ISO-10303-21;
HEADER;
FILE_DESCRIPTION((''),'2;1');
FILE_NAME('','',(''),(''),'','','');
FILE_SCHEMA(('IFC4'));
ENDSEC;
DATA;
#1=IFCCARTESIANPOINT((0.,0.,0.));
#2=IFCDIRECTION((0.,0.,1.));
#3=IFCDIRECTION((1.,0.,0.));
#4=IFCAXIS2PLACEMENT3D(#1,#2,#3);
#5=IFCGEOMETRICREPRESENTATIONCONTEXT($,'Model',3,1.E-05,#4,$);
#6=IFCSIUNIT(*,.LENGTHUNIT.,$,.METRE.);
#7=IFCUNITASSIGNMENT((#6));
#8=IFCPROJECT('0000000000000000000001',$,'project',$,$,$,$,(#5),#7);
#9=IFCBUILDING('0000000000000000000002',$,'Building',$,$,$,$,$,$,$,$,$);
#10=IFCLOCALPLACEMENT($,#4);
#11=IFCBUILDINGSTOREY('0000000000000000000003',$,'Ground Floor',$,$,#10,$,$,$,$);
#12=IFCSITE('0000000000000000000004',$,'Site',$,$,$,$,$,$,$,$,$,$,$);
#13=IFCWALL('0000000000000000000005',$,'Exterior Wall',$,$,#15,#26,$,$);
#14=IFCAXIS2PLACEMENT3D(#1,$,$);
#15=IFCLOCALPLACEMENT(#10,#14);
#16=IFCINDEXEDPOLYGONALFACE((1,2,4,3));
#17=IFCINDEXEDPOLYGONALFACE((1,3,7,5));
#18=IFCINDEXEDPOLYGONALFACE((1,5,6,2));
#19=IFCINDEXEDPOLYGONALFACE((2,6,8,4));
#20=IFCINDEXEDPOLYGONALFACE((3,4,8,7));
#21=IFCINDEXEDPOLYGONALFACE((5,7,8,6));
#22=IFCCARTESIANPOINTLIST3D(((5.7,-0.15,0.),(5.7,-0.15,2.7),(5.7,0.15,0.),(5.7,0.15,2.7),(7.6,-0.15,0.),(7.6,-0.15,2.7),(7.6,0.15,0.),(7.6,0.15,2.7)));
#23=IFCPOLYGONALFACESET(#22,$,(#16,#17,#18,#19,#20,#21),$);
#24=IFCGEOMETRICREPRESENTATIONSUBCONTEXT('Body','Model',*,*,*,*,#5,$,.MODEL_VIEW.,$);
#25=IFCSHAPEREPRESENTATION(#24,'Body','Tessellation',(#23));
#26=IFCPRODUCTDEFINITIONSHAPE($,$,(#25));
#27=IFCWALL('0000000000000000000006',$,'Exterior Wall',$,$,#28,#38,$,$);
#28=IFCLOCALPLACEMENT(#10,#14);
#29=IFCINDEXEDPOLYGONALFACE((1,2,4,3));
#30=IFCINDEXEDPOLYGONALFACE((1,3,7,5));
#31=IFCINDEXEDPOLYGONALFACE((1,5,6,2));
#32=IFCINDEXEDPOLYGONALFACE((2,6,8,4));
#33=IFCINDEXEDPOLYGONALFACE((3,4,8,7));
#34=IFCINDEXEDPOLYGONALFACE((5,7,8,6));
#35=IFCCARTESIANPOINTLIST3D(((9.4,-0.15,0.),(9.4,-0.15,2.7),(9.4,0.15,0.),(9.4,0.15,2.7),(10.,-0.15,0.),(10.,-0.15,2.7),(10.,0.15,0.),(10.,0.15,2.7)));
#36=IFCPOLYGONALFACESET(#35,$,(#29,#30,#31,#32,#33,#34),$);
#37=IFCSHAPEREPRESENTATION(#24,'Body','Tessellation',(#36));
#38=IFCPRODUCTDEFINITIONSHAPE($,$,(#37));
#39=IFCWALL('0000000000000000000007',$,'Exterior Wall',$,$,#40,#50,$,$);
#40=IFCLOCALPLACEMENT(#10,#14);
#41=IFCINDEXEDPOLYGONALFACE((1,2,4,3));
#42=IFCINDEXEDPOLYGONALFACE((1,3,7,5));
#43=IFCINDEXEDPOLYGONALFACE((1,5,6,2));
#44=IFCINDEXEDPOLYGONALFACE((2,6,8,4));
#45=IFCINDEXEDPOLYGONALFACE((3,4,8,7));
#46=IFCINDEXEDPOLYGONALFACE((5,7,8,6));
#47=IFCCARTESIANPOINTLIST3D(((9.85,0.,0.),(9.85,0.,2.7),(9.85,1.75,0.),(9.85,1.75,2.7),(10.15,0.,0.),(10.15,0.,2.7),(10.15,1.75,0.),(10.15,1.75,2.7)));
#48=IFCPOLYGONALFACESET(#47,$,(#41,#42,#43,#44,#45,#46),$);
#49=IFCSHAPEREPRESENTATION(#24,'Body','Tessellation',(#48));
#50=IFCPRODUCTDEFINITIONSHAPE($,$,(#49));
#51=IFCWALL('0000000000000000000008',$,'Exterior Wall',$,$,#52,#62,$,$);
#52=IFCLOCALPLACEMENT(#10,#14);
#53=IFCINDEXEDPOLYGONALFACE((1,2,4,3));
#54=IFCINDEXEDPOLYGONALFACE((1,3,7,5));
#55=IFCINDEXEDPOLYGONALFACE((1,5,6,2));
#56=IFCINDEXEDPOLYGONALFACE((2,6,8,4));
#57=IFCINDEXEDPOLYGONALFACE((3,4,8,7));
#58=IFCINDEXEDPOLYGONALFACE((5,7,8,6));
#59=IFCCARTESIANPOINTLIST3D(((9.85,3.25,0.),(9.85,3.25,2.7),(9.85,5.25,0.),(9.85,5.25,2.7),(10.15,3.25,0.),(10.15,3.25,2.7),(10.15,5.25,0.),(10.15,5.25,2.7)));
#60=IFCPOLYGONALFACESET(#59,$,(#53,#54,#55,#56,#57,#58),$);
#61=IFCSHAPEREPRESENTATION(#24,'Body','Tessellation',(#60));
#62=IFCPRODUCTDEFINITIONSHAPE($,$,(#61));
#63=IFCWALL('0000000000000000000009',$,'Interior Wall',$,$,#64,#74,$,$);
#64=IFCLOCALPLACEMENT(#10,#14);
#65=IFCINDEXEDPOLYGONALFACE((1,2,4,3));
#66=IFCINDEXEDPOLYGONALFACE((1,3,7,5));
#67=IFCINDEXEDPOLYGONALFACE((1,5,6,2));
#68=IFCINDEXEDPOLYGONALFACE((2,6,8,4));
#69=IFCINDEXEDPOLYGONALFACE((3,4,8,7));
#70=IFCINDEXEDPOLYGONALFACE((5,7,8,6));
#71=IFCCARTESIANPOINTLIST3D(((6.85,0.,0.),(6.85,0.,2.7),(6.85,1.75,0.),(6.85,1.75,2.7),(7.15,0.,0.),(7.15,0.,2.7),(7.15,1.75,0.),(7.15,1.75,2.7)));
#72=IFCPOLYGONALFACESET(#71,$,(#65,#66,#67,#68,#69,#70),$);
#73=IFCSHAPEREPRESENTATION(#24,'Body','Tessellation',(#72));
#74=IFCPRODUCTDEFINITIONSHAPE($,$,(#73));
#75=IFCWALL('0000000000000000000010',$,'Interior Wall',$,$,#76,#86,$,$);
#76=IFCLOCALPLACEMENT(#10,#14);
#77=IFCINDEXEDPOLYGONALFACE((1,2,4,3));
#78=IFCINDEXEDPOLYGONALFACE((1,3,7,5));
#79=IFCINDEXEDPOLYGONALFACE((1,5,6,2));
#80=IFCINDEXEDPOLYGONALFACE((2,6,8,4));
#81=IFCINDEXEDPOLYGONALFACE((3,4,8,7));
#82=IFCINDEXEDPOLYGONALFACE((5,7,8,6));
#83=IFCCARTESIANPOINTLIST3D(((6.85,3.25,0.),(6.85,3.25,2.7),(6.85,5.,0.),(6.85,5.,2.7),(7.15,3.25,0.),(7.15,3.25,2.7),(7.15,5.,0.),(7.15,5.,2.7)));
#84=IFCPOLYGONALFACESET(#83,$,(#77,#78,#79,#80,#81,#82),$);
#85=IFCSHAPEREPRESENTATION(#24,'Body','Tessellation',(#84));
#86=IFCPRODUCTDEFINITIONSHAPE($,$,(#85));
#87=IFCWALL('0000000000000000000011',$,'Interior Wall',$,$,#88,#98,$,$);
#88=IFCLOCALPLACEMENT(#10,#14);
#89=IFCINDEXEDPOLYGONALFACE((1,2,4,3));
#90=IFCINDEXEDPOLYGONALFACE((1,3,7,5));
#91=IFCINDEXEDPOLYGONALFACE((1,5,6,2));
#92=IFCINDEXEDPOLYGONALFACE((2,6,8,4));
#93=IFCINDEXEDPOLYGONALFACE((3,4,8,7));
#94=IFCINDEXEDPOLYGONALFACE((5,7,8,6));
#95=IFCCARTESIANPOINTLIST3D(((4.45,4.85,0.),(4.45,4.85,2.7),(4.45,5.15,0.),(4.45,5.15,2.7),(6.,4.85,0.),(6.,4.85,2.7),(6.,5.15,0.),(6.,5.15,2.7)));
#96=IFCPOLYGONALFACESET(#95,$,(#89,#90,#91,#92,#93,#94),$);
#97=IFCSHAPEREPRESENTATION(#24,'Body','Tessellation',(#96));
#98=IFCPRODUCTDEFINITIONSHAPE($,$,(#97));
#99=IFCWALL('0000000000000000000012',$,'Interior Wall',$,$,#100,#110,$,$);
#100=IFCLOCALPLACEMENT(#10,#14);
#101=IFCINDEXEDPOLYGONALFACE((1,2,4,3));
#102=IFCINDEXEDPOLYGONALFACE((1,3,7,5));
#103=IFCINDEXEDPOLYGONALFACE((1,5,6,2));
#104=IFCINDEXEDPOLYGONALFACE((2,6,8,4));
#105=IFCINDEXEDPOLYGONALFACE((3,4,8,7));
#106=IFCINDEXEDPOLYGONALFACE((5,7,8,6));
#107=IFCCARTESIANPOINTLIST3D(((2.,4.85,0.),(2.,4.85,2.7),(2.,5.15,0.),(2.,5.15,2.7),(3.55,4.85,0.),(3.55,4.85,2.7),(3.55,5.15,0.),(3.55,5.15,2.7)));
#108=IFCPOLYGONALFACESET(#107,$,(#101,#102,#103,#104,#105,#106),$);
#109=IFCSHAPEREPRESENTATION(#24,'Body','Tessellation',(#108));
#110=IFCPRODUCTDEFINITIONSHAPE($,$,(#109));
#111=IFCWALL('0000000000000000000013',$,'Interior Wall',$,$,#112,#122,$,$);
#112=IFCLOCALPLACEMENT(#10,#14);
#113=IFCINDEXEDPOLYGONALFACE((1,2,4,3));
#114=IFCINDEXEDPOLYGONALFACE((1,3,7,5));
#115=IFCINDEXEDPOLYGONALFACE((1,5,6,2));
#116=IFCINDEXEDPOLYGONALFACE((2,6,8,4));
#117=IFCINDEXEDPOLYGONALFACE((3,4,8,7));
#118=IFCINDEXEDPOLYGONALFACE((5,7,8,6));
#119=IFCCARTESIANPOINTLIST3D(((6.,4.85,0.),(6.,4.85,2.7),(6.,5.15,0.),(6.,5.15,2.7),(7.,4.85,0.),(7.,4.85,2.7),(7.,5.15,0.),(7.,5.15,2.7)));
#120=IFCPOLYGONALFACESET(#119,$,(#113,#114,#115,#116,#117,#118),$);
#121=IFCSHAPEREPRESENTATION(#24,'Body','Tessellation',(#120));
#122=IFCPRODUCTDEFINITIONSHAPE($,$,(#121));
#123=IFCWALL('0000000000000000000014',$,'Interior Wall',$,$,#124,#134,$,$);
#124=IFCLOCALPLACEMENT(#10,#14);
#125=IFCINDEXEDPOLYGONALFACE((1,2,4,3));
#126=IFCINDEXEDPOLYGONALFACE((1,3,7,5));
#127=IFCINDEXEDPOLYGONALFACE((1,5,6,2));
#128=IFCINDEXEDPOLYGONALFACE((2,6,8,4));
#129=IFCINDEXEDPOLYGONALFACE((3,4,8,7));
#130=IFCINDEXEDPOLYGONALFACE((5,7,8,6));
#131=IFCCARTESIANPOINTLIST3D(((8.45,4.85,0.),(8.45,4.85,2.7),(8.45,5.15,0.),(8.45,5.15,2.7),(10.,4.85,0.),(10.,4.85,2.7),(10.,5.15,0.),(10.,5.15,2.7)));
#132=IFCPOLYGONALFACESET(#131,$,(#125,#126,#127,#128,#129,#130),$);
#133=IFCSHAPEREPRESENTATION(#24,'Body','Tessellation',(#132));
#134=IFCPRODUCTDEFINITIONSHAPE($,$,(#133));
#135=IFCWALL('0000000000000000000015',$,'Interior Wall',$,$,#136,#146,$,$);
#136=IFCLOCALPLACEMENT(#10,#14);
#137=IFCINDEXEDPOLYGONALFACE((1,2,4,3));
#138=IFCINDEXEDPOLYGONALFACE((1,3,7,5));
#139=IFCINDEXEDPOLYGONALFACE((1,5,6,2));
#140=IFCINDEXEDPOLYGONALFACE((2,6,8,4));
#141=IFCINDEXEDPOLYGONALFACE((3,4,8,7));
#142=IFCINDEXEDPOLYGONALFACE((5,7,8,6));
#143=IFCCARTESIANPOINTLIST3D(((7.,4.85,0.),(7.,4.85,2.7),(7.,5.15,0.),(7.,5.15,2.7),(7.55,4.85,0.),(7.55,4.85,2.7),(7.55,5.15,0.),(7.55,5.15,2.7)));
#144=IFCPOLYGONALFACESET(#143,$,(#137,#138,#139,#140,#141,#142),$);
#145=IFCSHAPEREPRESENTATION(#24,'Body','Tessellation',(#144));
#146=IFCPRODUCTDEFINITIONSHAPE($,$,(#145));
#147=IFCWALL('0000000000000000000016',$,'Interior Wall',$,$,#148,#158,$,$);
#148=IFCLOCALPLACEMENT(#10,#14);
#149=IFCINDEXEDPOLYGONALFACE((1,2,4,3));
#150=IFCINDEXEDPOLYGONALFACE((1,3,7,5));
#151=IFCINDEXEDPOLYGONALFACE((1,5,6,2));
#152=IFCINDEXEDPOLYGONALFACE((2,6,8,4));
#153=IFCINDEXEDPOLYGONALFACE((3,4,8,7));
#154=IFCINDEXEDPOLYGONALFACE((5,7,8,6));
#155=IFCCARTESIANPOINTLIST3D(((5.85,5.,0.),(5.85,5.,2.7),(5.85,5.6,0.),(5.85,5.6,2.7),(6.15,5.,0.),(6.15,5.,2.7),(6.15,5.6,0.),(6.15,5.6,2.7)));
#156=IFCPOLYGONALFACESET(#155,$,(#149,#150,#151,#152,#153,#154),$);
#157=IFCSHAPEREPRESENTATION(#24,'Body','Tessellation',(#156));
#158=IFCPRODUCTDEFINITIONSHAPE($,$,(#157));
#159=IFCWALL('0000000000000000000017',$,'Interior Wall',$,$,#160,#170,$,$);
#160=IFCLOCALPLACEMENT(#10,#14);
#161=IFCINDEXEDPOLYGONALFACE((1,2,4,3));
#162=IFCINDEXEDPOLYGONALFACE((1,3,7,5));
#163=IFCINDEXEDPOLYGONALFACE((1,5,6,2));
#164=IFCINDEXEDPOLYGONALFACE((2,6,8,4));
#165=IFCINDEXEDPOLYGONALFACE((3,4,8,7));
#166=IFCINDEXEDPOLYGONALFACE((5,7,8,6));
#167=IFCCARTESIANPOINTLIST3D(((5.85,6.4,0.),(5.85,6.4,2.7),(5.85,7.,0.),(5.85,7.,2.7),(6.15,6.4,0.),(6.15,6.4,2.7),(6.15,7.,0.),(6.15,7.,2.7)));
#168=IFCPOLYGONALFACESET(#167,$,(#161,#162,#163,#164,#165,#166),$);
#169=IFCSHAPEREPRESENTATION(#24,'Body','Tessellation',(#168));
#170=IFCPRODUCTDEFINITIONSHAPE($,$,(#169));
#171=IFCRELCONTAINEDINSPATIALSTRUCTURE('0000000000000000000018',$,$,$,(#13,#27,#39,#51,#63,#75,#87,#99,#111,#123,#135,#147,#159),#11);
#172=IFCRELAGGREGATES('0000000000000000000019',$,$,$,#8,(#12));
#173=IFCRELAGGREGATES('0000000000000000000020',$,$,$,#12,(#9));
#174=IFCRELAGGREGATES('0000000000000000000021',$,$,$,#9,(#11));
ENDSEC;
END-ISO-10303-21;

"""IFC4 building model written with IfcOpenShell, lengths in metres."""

from ifc_helpers import new_model, si_unit, frame, origin_with_axes, place, context, subcontext, project, spatial, indexed_curve, outline, extrude, element, save


model = new_model("IFC4")

# Units and contexts
model_context = context("Model", 3, precision=1e-05, world=origin_with_axes())
body_context = subcontext(model_context, "Body", "Model", "MODEL_VIEW")
ifc_project = project(units=[si_unit("LENGTHUNIT", "METRE")], contexts=[model_context])

# Site, building, storey
site = spatial("IfcSite", under=ifc_project, Name="Site")
building = spatial("IfcBuilding", under=site, Name="Building")
storey_placement = place(None, origin_with_axes())
storey = spatial("IfcBuildingStorey", under=building, at=storey_placement, Name="Ground Floor")

# Walls
wall_1_placement = place(storey_placement, frame((5.7, 0.0, 0.0), z_axis=(0.0, 0.0, 1.0), x_axis=(1.0, 0.0, 0.0)))
element("IfcWall", 1, at=wall_1_placement, inside=storey, Name="Exterior Wall", context=body_context, shape_type="SweptSolid", body=[
    extrude(outline(indexed_curve([(0.0, 0.0), (0.0, 0.3), (1.9, 0.3), (1.9, 0.0), (0.0, 0.0)], self_intersect=False)), frame((0.0, -0.15, 0.0), z_axis=(0.0, 0.0, 1.0), x_axis=(1.0, 0.0, 0.0)), (0.0, 0.0, 1.0), 2.7),
])
wall_2_placement = place(storey_placement, frame((9.4, 0.0, 0.0), z_axis=(0.0, 0.0, 1.0), x_axis=(1.0, 0.0, 0.0)))
element("IfcWall", 2, at=wall_2_placement, inside=storey, Name="Exterior Wall", context=body_context, shape_type="SweptSolid", body=[
    extrude(outline(indexed_curve([(0.0, 0.0), (0.0, 0.3), (0.6, 0.3), (0.6, 0.0), (0.0, 0.0)], self_intersect=False)), frame((0.0, -0.15, 0.0), z_axis=(0.0, 0.0, 1.0), x_axis=(1.0, 0.0, 0.0)), (0.0, 0.0, 1.0), 2.7),
])
wall_3_placement = place(storey_placement, frame((10.0, 0.0, 0.0), z_axis=(0.0, 0.0, 1.0), x_axis=(0.0, 1.0, 0.0)))
element("IfcWall", 3, at=wall_3_placement, inside=storey, Name="Exterior Wall", context=body_context, shape_type="SweptSolid", body=[
    extrude(outline(indexed_curve([(0.0, 0.0), (0.0, 0.3), (1.75, 0.3), (1.75, 0.0), (0.0, 0.0)], self_intersect=False)), frame((0.0, -0.15, 0.0), z_axis=(0.0, 0.0, 1.0), x_axis=(1.0, 0.0, 0.0)), (0.0, 0.0, 1.0), 2.7),
])
wall_4_placement = place(storey_placement, frame((10.0, 3.25, 0.0), z_axis=(0.0, 0.0, 1.0), x_axis=(0.0, 1.0, 0.0)))
element("IfcWall", 4, at=wall_4_placement, inside=storey, Name="Exterior Wall", context=body_context, shape_type="SweptSolid", body=[
    extrude(outline(indexed_curve([(0.0, 0.0), (0.0, 0.3), (2.0, 0.3), (2.0, 0.0), (0.0, 0.0)], self_intersect=False)), frame((0.0, -0.15, 0.0), z_axis=(0.0, 0.0, 1.0), x_axis=(1.0, 0.0, 0.0)), (0.0, 0.0, 1.0), 2.7),
])
for number, where, z_axis, x_axis, name in (
    (5, (7.0, 0.0, 0.0), (0.0, 0.0, 1.0), (0.0, 1.0, 0.0), "Interior Wall"),
    (6, (7.0, 3.25, 0.0), (0.0, 0.0, 1.0), (0.0, 1.0, 0.0), "Interior Wall"),
):
    element("IfcWall", number, at=place(storey_placement, frame(where, z_axis=z_axis, x_axis=x_axis)), inside=storey, Name=name, context=body_context, shape_type="SweptSolid", body=[
        extrude(outline(indexed_curve([(0.0, 0.0), (0.0, 0.3), (1.75, 0.3), (1.75, 0.0), (0.0, 0.0)], self_intersect=False)), frame((0.0, -0.15, 0.0), z_axis=(0.0, 0.0, 1.0), x_axis=(1.0, 0.0, 0.0)), (0.0, 0.0, 1.0), 2.7),
    ])
for number, where, z_axis, x_axis, name in (
    (7, (6.0, 5.0, 0.0), (0.0, 0.0, 1.0), (-1.0, 0.0, 0.0), "Interior Wall"),
    (8, (3.55, 5.0, 0.0), (0.0, 0.0, 1.0), (-1.0, 0.0, 0.0), "Interior Wall"),
):
    element("IfcWall", number, at=place(storey_placement, frame(where, z_axis=z_axis, x_axis=x_axis)), inside=storey, Name=name, context=body_context, shape_type="SweptSolid", body=[
        extrude(outline(indexed_curve([(0.0, 0.0), (0.0, 0.3), (1.55, 0.3), (1.55, 0.0), (0.0, 0.0)], self_intersect=False)), frame((0.0, -0.15, 0.0), z_axis=(0.0, 0.0, 1.0), x_axis=(1.0, 0.0, 0.0)), (0.0, 0.0, 1.0), 2.7),
    ])
wall_5_placement = place(storey_placement, frame((7.0, 5.0, 0.0), z_axis=(0.0, 0.0, 1.0), x_axis=(-1.0, 0.0, 0.0)))
element("IfcWall", 9, at=wall_5_placement, inside=storey, Name="Interior Wall", context=body_context, shape_type="SweptSolid", body=[
    extrude(outline(indexed_curve([(0.0, 0.0), (0.0, 0.3), (1.0, 0.3), (1.0, 0.0), (0.0, 0.0)], self_intersect=False)), frame((0.0, -0.15, 0.0), z_axis=(0.0, 0.0, 1.0), x_axis=(1.0, 0.0, 0.0)), (0.0, 0.0, 1.0), 2.7),
])
wall_6_placement = place(storey_placement, frame((10.0, 5.0, 0.0), z_axis=(0.0, 0.0, 1.0), x_axis=(-1.0, 0.0, 0.0)))
element("IfcWall", 10, at=wall_6_placement, inside=storey, Name="Interior Wall", context=body_context, shape_type="SweptSolid", body=[
    extrude(outline(indexed_curve([(0.0, 0.0), (0.0, 0.3), (1.55, 0.3), (1.55, 0.0), (0.0, 0.0)], self_intersect=False)), frame((0.0, -0.15, 0.0), z_axis=(0.0, 0.0, 1.0), x_axis=(1.0, 0.0, 0.0)), (0.0, 0.0, 1.0), 2.7),
])
wall_7_placement = place(storey_placement, frame((7.55, 5.0, 0.0), z_axis=(0.0, 0.0, 1.0), x_axis=(-1.0, 0.0, 0.0)))
element("IfcWall", 11, at=wall_7_placement, inside=storey, Name="Interior Wall", context=body_context, shape_type="SweptSolid", body=[
    extrude(outline(indexed_curve([(0.0, 0.0), (0.0, 0.3), (0.55, 0.3), (0.55, 0.0), (0.0, 0.0)], self_intersect=False)), frame((0.0, -0.15, 0.0), z_axis=(0.0, 0.0, 1.0), x_axis=(1.0, 0.0, 0.0)), (0.0, 0.0, 1.0), 2.7),
])
for number, where, z_axis, x_axis, name in (
    (12, (6.0, 5.0, 0.0), (0.0, 0.0, 1.0), (0.0, 1.0, 0.0), "Interior Wall"),
    (13, (6.0, 6.4, 0.0), (0.0, 0.0, 1.0), (0.0, 1.0, 0.0), "Interior Wall"),
):
    element("IfcWall", number, at=place(storey_placement, frame(where, z_axis=z_axis, x_axis=x_axis)), inside=storey, Name=name, context=body_context, shape_type="SweptSolid", body=[
        extrude(outline(indexed_curve([(0.0, 0.0), (0.0, 0.3), (0.6, 0.3), (0.6, 0.0), (0.0, 0.0)], self_intersect=False)), frame((0.0, -0.15, 0.0), z_axis=(0.0, 0.0, 1.0), x_axis=(1.0, 0.0, 0.0)), (0.0, 0.0, 1.0), 2.7),
    ])

save(model, "model.ifc")
